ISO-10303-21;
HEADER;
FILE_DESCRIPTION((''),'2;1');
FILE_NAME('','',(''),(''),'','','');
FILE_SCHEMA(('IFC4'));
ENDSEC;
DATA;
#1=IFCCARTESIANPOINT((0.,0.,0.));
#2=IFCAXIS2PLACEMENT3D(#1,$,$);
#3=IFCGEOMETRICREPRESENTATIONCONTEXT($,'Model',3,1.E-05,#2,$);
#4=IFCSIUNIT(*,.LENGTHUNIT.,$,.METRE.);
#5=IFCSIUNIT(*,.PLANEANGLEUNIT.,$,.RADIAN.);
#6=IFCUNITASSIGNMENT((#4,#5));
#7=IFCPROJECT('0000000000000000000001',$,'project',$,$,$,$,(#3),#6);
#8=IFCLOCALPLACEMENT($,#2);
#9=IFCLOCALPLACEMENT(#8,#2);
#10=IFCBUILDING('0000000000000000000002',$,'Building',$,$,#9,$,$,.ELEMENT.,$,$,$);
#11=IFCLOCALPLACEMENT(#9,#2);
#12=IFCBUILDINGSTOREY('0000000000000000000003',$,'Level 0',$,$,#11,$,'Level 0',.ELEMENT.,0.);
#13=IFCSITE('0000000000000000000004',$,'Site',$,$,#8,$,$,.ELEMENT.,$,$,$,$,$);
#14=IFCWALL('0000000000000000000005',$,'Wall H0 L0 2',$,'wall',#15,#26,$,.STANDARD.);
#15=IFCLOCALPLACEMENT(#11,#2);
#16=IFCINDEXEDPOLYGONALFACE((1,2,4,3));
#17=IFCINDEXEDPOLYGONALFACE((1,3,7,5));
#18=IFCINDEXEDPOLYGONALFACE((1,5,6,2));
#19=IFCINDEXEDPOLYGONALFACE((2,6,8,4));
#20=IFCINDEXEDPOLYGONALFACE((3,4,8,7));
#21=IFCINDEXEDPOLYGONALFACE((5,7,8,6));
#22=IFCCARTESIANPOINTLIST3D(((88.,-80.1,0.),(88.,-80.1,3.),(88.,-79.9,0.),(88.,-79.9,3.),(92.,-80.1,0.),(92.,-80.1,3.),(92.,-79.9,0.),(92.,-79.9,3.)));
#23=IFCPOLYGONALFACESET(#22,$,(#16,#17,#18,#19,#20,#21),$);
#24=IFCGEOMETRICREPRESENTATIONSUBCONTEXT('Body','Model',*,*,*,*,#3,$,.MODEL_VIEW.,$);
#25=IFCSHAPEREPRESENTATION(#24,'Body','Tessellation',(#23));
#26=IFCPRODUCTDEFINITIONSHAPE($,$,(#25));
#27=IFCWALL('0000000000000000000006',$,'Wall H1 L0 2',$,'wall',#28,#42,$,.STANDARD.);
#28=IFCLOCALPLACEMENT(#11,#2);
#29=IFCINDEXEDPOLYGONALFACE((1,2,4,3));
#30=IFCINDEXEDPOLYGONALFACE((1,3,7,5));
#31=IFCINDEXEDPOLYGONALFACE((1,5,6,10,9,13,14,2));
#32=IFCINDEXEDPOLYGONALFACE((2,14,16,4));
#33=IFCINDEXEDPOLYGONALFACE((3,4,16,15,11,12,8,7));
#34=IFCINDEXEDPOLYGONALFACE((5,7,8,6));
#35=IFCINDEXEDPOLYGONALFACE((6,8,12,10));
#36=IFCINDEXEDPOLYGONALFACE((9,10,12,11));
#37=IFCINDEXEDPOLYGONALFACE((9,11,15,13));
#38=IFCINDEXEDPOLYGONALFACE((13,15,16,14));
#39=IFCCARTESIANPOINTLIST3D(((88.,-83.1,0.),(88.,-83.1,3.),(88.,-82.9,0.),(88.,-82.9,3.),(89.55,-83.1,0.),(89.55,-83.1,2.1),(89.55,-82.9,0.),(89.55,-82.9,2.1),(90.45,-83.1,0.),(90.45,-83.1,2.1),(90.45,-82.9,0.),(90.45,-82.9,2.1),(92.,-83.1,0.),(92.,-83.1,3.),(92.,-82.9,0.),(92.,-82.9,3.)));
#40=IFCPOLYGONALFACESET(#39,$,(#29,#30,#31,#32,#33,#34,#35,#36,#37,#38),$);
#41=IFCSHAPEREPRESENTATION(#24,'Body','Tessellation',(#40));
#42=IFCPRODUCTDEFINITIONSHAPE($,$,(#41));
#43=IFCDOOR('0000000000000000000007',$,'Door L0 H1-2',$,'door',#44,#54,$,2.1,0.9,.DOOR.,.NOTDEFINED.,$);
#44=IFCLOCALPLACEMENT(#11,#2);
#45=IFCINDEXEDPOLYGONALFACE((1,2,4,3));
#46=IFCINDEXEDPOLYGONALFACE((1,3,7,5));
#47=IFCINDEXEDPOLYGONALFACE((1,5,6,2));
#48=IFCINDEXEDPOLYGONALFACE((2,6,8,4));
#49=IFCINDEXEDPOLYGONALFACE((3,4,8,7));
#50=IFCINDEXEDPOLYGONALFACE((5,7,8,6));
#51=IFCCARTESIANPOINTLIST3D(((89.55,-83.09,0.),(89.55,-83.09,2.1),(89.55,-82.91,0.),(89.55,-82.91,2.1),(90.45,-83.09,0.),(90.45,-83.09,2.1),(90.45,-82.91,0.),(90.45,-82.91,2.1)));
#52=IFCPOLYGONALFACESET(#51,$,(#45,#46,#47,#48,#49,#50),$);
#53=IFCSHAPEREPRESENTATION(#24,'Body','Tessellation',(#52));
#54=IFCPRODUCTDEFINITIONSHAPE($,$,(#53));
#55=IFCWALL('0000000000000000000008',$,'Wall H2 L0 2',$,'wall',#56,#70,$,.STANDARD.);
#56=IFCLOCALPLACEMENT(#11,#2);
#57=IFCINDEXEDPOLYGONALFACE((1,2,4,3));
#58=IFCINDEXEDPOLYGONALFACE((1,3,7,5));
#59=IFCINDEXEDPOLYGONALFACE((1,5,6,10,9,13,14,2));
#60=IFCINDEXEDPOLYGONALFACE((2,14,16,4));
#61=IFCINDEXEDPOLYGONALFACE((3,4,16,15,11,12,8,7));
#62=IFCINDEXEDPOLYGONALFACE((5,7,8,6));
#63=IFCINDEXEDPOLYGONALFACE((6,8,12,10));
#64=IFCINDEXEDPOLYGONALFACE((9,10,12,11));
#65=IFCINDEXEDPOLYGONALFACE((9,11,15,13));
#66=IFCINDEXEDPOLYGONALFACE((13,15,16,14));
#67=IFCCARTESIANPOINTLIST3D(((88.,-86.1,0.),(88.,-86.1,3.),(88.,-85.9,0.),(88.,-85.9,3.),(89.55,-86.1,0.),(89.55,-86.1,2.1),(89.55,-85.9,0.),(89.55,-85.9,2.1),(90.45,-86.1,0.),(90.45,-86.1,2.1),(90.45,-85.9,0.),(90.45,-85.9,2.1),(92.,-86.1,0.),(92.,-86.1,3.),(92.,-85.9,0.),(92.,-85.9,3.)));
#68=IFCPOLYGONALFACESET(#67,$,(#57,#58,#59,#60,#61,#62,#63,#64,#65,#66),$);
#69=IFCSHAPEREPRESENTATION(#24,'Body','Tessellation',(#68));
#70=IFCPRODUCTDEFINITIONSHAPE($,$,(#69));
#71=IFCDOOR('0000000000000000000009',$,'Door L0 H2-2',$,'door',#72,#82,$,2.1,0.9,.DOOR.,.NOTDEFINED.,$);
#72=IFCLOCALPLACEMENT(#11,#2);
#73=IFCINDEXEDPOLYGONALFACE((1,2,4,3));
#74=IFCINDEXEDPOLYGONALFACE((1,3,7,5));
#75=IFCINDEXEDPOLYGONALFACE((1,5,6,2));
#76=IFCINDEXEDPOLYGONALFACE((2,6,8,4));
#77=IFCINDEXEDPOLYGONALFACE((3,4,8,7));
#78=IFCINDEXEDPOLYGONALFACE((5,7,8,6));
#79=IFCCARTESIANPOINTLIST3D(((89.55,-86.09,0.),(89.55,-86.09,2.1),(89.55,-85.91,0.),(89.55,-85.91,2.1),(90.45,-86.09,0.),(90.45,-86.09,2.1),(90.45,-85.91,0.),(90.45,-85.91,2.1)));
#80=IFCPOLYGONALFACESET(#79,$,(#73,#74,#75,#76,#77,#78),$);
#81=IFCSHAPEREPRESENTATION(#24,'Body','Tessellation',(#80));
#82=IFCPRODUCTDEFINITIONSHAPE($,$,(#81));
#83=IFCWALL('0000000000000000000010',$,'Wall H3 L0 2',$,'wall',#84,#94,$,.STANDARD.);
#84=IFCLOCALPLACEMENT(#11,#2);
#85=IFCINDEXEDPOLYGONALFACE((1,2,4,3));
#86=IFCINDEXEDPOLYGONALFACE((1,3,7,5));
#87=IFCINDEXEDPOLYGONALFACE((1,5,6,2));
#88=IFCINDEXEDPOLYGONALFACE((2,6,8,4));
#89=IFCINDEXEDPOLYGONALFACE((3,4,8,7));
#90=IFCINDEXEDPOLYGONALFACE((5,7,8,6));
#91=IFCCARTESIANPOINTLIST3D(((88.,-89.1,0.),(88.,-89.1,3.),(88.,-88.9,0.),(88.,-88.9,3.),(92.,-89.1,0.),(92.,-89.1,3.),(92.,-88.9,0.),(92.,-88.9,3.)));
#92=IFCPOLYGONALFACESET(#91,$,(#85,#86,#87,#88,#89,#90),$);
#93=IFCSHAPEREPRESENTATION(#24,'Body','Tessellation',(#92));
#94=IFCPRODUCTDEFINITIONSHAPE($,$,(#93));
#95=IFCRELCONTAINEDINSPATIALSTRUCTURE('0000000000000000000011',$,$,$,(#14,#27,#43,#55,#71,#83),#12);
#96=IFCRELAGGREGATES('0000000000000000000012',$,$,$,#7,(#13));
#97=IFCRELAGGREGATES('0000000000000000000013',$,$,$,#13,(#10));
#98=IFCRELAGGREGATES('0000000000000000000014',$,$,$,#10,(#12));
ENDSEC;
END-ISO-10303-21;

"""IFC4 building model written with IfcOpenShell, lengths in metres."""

from ifc_helpers import new_model, si_unit, frame, frame_2d, origin, origin_2d, place, context, subcontext, project, spatial, rectangle, extrude, element, fill, save


model = new_model("IFC4")

# Units and contexts
model_context = context("Model", 3, precision=1e-05, world=origin())
body_context = subcontext(model_context, "Body", "Model", "MODEL_VIEW")
ifc_project = project(units=[si_unit("LENGTHUNIT", "METRE"), si_unit("PLANEANGLEUNIT", "RADIAN")], contexts=[model_context])

# Site, building, storey
site_placement = place(None, origin())
site = spatial("IfcSite", under=ifc_project, at=site_placement, Name="Site", CompositionType="ELEMENT")
building_placement = place(site_placement, origin())
building = spatial("IfcBuilding", under=site, at=building_placement, Name="Building", CompositionType="ELEMENT")
storey_placement = place(building_placement, origin())
storey = spatial("IfcBuildingStorey", under=building, at=storey_placement, Name="Level 0", LongName="Level 0", CompositionType="ELEMENT", Elevation=0.0)

# Wall
wall_1_placement = place(storey_placement, frame((88.0, -80.0, 0.0), z_axis=(0.0, 0.0, 1.0), x_axis=(1.0, 0.0, 0.0)))
element("IfcWall", 1, at=wall_1_placement, inside=storey, Name="Wall H0 L0 2", ObjectType="wall", PredefinedType="STANDARD", context=body_context, shape_type="SweptSolid", body=[
    extrude(rectangle(XDim=4.0, YDim=0.2, at=frame_2d((2.0, 0.0))), origin(), (0.0, 0.0, 1.0), 3.0),
])

# Walls, openings, doors
wall_2_placement = place(storey_placement, frame((88.0, -83.0, 0.0), z_axis=(0.0, 0.0, 1.0), x_axis=(1.0, 0.0, 0.0)))
wall_2 = element("IfcWall", 2, at=wall_2_placement, inside=storey, Name="Wall H1 L0 2", ObjectType="wall", PredefinedType="STANDARD", context=body_context, shape_type="SweptSolid", body=[
    extrude(rectangle(XDim=4.0, YDim=0.2, at=frame_2d((2.0, 0.0))), origin(), (0.0, 0.0, 1.0), 3.0),
])
opening_1_placement = place(storey_placement, frame((90.0, -83.0, 0.0), z_axis=(0.0, 0.0, 1.0), x_axis=(1.0, 0.0, 0.0)))
opening_1 = element("IfcOpeningElement", 3, at=opening_1_placement, cuts=wall_2, ObjectType="Opening", PredefinedType="OPENING", context=body_context, shape_type="SweptSolid", body=[
    extrude(rectangle(XDim=0.9, YDim=0.22, at=origin_2d()), origin(), (0.0, 0.0, 1.0), 2.1),
])
door_1_placement = place(storey_placement, frame((90.0, -83.0, 0.0), z_axis=(0.0, 0.0, 1.0), x_axis=(1.0, 0.0, 0.0)))
door_1 = element("IfcDoor", 4, at=door_1_placement, inside=storey, Name="Door L0 H1-2", ObjectType="door", OperationType="NOTDEFINED", OverallHeight=2.1, OverallWidth=0.9, PredefinedType="DOOR", context=body_context, shape_type="SweptSolid", body=[
    extrude(rectangle(XDim=0.9, YDim=0.18, at=origin_2d()), origin(), (0.0, 0.0, 1.0), 2.1),
])
fill(opening_1, door_1)
wall_3_placement = place(storey_placement, frame((88.0, -86.0, 0.0), z_axis=(0.0, 0.0, 1.0), x_axis=(1.0, 0.0, 0.0)))
wall_3 = element("IfcWall", 5, at=wall_3_placement, inside=storey, Name="Wall H2 L0 2", ObjectType="wall", PredefinedType="STANDARD", context=body_context, shape_type="SweptSolid", body=[
    extrude(rectangle(XDim=4.0, YDim=0.2, at=frame_2d((2.0, 0.0))), origin(), (0.0, 0.0, 1.0), 3.0),
])
opening_2_placement = place(storey_placement, frame((90.0, -86.0, 0.0), z_axis=(0.0, 0.0, 1.0), x_axis=(1.0, 0.0, 0.0)))
opening_2 = element("IfcOpeningElement", 6, at=opening_2_placement, cuts=wall_3, ObjectType="Opening", PredefinedType="OPENING", context=body_context, shape_type="SweptSolid", body=[
    extrude(rectangle(XDim=0.9, YDim=0.22, at=origin_2d()), origin(), (0.0, 0.0, 1.0), 2.1),
])
door_2_placement = place(storey_placement, frame((90.0, -86.0, 0.0), z_axis=(0.0, 0.0, 1.0), x_axis=(1.0, 0.0, 0.0)))
door_2 = element("IfcDoor", 7, at=door_2_placement, inside=storey, Name="Door L0 H2-2", ObjectType="door", OperationType="NOTDEFINED", OverallHeight=2.1, OverallWidth=0.9, PredefinedType="DOOR", context=body_context, shape_type="SweptSolid", body=[
    extrude(rectangle(XDim=0.9, YDim=0.18, at=origin_2d()), origin(), (0.0, 0.0, 1.0), 2.1),
])
fill(opening_2, door_2)

# Wall
wall_4_placement = place(storey_placement, frame((88.0, -89.0, 0.0), z_axis=(0.0, 0.0, 1.0), x_axis=(1.0, 0.0, 0.0)))
element("IfcWall", 8, at=wall_4_placement, inside=storey, Name="Wall H3 L0 2", ObjectType="wall", PredefinedType="STANDARD", context=body_context, shape_type="SweptSolid", body=[
    extrude(rectangle(XDim=4.0, YDim=0.2, at=frame_2d((2.0, 0.0))), origin(), (0.0, 0.0, 1.0), 3.0),
])

save(model, "model.ifc")
